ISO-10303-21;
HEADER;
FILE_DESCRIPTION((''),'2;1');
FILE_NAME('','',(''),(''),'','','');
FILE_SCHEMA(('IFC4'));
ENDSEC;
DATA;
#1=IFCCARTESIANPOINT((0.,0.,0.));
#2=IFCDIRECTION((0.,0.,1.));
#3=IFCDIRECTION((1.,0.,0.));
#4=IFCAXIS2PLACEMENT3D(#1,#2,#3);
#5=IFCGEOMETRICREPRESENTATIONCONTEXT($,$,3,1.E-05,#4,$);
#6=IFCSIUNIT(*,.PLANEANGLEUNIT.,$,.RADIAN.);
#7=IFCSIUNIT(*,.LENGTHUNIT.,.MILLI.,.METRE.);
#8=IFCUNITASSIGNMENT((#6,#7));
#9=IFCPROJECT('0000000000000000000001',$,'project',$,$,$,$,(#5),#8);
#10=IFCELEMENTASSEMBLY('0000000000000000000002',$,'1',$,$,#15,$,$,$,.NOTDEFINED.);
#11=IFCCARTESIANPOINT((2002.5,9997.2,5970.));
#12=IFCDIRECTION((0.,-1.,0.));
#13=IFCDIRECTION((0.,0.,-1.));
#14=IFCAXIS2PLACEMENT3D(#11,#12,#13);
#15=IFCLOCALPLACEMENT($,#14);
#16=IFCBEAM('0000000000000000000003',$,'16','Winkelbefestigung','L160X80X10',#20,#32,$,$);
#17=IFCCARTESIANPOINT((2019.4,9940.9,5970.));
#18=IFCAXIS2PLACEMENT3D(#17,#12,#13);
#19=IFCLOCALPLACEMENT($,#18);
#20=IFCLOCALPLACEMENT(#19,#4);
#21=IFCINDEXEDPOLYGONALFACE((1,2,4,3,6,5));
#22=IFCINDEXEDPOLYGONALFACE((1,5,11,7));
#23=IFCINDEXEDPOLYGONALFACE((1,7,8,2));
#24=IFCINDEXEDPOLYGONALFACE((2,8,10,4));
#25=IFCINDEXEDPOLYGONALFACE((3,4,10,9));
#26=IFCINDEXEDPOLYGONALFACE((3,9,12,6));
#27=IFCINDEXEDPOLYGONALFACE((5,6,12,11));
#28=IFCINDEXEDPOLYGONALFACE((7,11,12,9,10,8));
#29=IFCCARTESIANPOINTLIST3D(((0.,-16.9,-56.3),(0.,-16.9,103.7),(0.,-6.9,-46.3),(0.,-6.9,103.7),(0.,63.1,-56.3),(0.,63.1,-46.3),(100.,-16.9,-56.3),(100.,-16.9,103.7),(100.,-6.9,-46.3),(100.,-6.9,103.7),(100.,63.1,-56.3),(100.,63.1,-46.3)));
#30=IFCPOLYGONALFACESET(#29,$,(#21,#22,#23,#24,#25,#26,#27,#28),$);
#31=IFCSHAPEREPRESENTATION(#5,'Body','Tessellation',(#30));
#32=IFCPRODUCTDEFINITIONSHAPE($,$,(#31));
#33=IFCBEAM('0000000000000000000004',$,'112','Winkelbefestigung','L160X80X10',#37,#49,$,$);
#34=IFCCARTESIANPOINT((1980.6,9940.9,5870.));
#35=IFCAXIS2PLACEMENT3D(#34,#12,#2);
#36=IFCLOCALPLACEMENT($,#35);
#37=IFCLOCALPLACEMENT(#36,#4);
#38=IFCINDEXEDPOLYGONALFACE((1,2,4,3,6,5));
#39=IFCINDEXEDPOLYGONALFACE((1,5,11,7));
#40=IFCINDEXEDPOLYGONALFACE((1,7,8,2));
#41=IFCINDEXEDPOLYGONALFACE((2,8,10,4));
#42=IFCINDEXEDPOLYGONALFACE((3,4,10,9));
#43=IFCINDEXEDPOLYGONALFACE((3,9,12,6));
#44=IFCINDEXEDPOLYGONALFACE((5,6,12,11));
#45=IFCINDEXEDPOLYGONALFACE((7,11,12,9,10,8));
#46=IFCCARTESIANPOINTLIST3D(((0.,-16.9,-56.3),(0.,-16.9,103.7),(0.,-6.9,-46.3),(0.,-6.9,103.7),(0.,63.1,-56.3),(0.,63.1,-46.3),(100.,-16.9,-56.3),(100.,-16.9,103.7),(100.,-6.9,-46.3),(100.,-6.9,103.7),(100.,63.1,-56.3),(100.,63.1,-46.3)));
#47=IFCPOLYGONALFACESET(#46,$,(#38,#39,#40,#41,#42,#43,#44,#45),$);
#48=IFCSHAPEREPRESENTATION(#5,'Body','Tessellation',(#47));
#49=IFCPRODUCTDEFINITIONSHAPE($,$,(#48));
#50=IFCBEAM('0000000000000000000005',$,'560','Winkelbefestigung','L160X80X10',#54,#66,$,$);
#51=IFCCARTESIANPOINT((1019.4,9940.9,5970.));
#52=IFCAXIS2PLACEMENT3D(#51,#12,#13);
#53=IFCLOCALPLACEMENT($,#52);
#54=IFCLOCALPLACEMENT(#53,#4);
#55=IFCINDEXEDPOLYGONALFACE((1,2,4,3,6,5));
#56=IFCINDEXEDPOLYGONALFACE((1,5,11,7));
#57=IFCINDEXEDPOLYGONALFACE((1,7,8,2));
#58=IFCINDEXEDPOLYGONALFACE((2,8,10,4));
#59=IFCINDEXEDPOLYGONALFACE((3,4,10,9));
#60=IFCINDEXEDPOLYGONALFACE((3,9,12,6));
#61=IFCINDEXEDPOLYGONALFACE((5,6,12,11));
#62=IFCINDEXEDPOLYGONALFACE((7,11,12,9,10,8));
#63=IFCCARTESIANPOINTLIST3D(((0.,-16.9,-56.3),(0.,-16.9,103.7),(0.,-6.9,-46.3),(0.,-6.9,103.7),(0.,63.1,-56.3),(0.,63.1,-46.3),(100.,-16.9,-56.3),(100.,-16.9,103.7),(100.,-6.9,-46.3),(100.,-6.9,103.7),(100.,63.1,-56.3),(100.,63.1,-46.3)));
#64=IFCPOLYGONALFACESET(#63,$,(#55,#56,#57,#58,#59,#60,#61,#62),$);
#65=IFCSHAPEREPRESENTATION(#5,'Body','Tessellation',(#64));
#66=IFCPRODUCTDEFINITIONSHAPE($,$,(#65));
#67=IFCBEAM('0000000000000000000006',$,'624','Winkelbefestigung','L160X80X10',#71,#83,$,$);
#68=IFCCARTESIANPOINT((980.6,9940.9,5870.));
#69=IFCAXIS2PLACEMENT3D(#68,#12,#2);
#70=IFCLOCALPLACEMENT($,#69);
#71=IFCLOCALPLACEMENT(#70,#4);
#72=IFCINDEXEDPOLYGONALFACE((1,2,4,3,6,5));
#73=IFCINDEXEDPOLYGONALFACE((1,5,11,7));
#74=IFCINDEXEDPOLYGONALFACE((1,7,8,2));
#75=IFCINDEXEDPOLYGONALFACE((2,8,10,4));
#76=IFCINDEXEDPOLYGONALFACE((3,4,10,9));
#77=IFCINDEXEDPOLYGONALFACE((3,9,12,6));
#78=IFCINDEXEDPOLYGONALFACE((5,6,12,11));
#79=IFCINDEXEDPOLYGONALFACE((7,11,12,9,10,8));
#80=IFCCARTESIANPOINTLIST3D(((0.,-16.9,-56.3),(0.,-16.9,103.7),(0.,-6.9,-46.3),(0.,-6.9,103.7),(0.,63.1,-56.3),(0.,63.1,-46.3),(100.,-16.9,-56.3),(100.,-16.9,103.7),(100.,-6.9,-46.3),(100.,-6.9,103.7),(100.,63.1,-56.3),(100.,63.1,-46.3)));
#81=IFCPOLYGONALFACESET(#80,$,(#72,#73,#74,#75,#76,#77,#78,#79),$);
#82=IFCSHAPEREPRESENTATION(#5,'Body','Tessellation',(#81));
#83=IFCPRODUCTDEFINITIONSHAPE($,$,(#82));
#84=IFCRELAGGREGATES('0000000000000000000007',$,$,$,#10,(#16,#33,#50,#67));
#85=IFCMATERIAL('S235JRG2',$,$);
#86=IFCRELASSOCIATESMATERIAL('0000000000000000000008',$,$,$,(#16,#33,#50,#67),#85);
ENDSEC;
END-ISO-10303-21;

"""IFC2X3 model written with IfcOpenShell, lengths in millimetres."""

from ifc_helpers import new_model, si_unit, frame, origin_with_axes, place, context, project, polyline, outline, extrude, material, element, aggregate, save


model = new_model("IFC2X3")

# Units and contexts
context_of_model = context(None, 3, precision=1e-05, world=origin_with_axes())
ifc_project = project(units=[si_unit("PLANEANGLEUNIT", "RADIAN"), si_unit("LENGTHUNIT", "METRE", prefix="MILLI")], contexts=[context_of_model])

# Shared definitions
ifc_material = material(Name="S235JRG2")

# Element assembly, beams
assembly_1_placement = place(None, frame((2002.5, 9997.2, 5970.0), z_axis=(0.0, -1.0, 0.0), x_axis=(0.0, 0.0, -1.0)))
assembly_1 = element("IfcElementAssembly", 1, at=assembly_1_placement, Name="1", PredefinedType="NOTDEFINED")
placement_1 = place(None, frame((2019.4, 9940.9, 5970.0), z_axis=(0.0, -1.0, 0.0), x_axis=(0.0, 0.0, -1.0)))
beam_1_placement = place(placement_1, origin_with_axes())
beam_1 = element("IfcBeam", 2, at=beam_1_placement, material=ifc_material, Name="16", Description="Winkelbefestigung", ObjectType="L160X80X10", context=context_of_model, shape_type="SweptSolid", body=[
    extrude(outline(polyline([(-16.9, 103.7), (-16.9, -56.3), (63.1, -56.3), (63.1, -46.3), (-6.9, -46.3), (-6.9, 103.7), (-16.9, 103.7), (-16.9, 103.7)])), frame((0.0, 0.0, 0.0), z_axis=(1.0, 0.0, 0.0), x_axis=(0.0, 1.0, 0.0)), (0.0, 0.0, 1.0), 100.0),
])
placement_2 = place(None, frame((1980.6, 9940.9, 5870.0), z_axis=(0.0, -1.0, 0.0), x_axis=(0.0, 0.0, 1.0)))
beam_2_placement = place(placement_2, origin_with_axes())
beam_2 = element("IfcBeam", 3, at=beam_2_placement, material=ifc_material, Name="112", Description="Winkelbefestigung", ObjectType="L160X80X10", context=context_of_model, shape_type="SweptSolid", body=[
    extrude(outline(polyline([(-16.9, 103.7), (-16.9, -56.3), (63.1, -56.3), (63.1, -46.3), (-6.9, -46.3), (-6.9, 103.7), (-16.9, 103.7), (-16.9, 103.7)])), frame((0.0, 0.0, 0.0), z_axis=(1.0, 0.0, 0.0), x_axis=(0.0, 1.0, 0.0)), (0.0, 0.0, 1.0), 100.0),
])
placement_3 = place(None, frame((1019.4, 9940.9, 5970.0), z_axis=(0.0, -1.0, 0.0), x_axis=(0.0, 0.0, -1.0)))
beam_3_placement = place(placement_3, origin_with_axes())
beam_3 = element("IfcBeam", 4, at=beam_3_placement, material=ifc_material, Name="560", Description="Winkelbefestigung", ObjectType="L160X80X10", context=context_of_model, shape_type="SweptSolid", body=[
    extrude(outline(polyline([(-16.9, 103.7), (-16.9, -56.3), (63.1, -56.3), (63.1, -46.3), (-6.9, -46.3), (-6.9, 103.7), (-16.9, 103.7), (-16.9, 103.7)])), frame((0.0, 0.0, 0.0), z_axis=(1.0, 0.0, 0.0), x_axis=(0.0, 1.0, 0.0)), (0.0, 0.0, 1.0), 100.0),
])
placement_4 = place(None, frame((980.6, 9940.9, 5870.0), z_axis=(0.0, -1.0, 0.0), x_axis=(0.0, 0.0, 1.0)))
beam_4_placement = place(placement_4, origin_with_axes())
beam_4 = element("IfcBeam", 5, at=beam_4_placement, material=ifc_material, Name="624", Description="Winkelbefestigung", ObjectType="L160X80X10", context=context_of_model, shape_type="SweptSolid", body=[
    extrude(outline(polyline([(-16.9, 103.7), (-16.9, -56.3), (63.1, -56.3), (63.1, -46.3), (-6.9, -46.3), (-6.9, 103.7), (-16.9, 103.7), (-16.9, 103.7)])), frame((0.0, 0.0, 0.0), z_axis=(1.0, 0.0, 0.0), x_axis=(0.0, 1.0, 0.0)), (0.0, 0.0, 1.0), 100.0),
])
aggregate(assembly_1, [beam_1, beam_2, beam_3, beam_4])

save(model, "model.ifc")
